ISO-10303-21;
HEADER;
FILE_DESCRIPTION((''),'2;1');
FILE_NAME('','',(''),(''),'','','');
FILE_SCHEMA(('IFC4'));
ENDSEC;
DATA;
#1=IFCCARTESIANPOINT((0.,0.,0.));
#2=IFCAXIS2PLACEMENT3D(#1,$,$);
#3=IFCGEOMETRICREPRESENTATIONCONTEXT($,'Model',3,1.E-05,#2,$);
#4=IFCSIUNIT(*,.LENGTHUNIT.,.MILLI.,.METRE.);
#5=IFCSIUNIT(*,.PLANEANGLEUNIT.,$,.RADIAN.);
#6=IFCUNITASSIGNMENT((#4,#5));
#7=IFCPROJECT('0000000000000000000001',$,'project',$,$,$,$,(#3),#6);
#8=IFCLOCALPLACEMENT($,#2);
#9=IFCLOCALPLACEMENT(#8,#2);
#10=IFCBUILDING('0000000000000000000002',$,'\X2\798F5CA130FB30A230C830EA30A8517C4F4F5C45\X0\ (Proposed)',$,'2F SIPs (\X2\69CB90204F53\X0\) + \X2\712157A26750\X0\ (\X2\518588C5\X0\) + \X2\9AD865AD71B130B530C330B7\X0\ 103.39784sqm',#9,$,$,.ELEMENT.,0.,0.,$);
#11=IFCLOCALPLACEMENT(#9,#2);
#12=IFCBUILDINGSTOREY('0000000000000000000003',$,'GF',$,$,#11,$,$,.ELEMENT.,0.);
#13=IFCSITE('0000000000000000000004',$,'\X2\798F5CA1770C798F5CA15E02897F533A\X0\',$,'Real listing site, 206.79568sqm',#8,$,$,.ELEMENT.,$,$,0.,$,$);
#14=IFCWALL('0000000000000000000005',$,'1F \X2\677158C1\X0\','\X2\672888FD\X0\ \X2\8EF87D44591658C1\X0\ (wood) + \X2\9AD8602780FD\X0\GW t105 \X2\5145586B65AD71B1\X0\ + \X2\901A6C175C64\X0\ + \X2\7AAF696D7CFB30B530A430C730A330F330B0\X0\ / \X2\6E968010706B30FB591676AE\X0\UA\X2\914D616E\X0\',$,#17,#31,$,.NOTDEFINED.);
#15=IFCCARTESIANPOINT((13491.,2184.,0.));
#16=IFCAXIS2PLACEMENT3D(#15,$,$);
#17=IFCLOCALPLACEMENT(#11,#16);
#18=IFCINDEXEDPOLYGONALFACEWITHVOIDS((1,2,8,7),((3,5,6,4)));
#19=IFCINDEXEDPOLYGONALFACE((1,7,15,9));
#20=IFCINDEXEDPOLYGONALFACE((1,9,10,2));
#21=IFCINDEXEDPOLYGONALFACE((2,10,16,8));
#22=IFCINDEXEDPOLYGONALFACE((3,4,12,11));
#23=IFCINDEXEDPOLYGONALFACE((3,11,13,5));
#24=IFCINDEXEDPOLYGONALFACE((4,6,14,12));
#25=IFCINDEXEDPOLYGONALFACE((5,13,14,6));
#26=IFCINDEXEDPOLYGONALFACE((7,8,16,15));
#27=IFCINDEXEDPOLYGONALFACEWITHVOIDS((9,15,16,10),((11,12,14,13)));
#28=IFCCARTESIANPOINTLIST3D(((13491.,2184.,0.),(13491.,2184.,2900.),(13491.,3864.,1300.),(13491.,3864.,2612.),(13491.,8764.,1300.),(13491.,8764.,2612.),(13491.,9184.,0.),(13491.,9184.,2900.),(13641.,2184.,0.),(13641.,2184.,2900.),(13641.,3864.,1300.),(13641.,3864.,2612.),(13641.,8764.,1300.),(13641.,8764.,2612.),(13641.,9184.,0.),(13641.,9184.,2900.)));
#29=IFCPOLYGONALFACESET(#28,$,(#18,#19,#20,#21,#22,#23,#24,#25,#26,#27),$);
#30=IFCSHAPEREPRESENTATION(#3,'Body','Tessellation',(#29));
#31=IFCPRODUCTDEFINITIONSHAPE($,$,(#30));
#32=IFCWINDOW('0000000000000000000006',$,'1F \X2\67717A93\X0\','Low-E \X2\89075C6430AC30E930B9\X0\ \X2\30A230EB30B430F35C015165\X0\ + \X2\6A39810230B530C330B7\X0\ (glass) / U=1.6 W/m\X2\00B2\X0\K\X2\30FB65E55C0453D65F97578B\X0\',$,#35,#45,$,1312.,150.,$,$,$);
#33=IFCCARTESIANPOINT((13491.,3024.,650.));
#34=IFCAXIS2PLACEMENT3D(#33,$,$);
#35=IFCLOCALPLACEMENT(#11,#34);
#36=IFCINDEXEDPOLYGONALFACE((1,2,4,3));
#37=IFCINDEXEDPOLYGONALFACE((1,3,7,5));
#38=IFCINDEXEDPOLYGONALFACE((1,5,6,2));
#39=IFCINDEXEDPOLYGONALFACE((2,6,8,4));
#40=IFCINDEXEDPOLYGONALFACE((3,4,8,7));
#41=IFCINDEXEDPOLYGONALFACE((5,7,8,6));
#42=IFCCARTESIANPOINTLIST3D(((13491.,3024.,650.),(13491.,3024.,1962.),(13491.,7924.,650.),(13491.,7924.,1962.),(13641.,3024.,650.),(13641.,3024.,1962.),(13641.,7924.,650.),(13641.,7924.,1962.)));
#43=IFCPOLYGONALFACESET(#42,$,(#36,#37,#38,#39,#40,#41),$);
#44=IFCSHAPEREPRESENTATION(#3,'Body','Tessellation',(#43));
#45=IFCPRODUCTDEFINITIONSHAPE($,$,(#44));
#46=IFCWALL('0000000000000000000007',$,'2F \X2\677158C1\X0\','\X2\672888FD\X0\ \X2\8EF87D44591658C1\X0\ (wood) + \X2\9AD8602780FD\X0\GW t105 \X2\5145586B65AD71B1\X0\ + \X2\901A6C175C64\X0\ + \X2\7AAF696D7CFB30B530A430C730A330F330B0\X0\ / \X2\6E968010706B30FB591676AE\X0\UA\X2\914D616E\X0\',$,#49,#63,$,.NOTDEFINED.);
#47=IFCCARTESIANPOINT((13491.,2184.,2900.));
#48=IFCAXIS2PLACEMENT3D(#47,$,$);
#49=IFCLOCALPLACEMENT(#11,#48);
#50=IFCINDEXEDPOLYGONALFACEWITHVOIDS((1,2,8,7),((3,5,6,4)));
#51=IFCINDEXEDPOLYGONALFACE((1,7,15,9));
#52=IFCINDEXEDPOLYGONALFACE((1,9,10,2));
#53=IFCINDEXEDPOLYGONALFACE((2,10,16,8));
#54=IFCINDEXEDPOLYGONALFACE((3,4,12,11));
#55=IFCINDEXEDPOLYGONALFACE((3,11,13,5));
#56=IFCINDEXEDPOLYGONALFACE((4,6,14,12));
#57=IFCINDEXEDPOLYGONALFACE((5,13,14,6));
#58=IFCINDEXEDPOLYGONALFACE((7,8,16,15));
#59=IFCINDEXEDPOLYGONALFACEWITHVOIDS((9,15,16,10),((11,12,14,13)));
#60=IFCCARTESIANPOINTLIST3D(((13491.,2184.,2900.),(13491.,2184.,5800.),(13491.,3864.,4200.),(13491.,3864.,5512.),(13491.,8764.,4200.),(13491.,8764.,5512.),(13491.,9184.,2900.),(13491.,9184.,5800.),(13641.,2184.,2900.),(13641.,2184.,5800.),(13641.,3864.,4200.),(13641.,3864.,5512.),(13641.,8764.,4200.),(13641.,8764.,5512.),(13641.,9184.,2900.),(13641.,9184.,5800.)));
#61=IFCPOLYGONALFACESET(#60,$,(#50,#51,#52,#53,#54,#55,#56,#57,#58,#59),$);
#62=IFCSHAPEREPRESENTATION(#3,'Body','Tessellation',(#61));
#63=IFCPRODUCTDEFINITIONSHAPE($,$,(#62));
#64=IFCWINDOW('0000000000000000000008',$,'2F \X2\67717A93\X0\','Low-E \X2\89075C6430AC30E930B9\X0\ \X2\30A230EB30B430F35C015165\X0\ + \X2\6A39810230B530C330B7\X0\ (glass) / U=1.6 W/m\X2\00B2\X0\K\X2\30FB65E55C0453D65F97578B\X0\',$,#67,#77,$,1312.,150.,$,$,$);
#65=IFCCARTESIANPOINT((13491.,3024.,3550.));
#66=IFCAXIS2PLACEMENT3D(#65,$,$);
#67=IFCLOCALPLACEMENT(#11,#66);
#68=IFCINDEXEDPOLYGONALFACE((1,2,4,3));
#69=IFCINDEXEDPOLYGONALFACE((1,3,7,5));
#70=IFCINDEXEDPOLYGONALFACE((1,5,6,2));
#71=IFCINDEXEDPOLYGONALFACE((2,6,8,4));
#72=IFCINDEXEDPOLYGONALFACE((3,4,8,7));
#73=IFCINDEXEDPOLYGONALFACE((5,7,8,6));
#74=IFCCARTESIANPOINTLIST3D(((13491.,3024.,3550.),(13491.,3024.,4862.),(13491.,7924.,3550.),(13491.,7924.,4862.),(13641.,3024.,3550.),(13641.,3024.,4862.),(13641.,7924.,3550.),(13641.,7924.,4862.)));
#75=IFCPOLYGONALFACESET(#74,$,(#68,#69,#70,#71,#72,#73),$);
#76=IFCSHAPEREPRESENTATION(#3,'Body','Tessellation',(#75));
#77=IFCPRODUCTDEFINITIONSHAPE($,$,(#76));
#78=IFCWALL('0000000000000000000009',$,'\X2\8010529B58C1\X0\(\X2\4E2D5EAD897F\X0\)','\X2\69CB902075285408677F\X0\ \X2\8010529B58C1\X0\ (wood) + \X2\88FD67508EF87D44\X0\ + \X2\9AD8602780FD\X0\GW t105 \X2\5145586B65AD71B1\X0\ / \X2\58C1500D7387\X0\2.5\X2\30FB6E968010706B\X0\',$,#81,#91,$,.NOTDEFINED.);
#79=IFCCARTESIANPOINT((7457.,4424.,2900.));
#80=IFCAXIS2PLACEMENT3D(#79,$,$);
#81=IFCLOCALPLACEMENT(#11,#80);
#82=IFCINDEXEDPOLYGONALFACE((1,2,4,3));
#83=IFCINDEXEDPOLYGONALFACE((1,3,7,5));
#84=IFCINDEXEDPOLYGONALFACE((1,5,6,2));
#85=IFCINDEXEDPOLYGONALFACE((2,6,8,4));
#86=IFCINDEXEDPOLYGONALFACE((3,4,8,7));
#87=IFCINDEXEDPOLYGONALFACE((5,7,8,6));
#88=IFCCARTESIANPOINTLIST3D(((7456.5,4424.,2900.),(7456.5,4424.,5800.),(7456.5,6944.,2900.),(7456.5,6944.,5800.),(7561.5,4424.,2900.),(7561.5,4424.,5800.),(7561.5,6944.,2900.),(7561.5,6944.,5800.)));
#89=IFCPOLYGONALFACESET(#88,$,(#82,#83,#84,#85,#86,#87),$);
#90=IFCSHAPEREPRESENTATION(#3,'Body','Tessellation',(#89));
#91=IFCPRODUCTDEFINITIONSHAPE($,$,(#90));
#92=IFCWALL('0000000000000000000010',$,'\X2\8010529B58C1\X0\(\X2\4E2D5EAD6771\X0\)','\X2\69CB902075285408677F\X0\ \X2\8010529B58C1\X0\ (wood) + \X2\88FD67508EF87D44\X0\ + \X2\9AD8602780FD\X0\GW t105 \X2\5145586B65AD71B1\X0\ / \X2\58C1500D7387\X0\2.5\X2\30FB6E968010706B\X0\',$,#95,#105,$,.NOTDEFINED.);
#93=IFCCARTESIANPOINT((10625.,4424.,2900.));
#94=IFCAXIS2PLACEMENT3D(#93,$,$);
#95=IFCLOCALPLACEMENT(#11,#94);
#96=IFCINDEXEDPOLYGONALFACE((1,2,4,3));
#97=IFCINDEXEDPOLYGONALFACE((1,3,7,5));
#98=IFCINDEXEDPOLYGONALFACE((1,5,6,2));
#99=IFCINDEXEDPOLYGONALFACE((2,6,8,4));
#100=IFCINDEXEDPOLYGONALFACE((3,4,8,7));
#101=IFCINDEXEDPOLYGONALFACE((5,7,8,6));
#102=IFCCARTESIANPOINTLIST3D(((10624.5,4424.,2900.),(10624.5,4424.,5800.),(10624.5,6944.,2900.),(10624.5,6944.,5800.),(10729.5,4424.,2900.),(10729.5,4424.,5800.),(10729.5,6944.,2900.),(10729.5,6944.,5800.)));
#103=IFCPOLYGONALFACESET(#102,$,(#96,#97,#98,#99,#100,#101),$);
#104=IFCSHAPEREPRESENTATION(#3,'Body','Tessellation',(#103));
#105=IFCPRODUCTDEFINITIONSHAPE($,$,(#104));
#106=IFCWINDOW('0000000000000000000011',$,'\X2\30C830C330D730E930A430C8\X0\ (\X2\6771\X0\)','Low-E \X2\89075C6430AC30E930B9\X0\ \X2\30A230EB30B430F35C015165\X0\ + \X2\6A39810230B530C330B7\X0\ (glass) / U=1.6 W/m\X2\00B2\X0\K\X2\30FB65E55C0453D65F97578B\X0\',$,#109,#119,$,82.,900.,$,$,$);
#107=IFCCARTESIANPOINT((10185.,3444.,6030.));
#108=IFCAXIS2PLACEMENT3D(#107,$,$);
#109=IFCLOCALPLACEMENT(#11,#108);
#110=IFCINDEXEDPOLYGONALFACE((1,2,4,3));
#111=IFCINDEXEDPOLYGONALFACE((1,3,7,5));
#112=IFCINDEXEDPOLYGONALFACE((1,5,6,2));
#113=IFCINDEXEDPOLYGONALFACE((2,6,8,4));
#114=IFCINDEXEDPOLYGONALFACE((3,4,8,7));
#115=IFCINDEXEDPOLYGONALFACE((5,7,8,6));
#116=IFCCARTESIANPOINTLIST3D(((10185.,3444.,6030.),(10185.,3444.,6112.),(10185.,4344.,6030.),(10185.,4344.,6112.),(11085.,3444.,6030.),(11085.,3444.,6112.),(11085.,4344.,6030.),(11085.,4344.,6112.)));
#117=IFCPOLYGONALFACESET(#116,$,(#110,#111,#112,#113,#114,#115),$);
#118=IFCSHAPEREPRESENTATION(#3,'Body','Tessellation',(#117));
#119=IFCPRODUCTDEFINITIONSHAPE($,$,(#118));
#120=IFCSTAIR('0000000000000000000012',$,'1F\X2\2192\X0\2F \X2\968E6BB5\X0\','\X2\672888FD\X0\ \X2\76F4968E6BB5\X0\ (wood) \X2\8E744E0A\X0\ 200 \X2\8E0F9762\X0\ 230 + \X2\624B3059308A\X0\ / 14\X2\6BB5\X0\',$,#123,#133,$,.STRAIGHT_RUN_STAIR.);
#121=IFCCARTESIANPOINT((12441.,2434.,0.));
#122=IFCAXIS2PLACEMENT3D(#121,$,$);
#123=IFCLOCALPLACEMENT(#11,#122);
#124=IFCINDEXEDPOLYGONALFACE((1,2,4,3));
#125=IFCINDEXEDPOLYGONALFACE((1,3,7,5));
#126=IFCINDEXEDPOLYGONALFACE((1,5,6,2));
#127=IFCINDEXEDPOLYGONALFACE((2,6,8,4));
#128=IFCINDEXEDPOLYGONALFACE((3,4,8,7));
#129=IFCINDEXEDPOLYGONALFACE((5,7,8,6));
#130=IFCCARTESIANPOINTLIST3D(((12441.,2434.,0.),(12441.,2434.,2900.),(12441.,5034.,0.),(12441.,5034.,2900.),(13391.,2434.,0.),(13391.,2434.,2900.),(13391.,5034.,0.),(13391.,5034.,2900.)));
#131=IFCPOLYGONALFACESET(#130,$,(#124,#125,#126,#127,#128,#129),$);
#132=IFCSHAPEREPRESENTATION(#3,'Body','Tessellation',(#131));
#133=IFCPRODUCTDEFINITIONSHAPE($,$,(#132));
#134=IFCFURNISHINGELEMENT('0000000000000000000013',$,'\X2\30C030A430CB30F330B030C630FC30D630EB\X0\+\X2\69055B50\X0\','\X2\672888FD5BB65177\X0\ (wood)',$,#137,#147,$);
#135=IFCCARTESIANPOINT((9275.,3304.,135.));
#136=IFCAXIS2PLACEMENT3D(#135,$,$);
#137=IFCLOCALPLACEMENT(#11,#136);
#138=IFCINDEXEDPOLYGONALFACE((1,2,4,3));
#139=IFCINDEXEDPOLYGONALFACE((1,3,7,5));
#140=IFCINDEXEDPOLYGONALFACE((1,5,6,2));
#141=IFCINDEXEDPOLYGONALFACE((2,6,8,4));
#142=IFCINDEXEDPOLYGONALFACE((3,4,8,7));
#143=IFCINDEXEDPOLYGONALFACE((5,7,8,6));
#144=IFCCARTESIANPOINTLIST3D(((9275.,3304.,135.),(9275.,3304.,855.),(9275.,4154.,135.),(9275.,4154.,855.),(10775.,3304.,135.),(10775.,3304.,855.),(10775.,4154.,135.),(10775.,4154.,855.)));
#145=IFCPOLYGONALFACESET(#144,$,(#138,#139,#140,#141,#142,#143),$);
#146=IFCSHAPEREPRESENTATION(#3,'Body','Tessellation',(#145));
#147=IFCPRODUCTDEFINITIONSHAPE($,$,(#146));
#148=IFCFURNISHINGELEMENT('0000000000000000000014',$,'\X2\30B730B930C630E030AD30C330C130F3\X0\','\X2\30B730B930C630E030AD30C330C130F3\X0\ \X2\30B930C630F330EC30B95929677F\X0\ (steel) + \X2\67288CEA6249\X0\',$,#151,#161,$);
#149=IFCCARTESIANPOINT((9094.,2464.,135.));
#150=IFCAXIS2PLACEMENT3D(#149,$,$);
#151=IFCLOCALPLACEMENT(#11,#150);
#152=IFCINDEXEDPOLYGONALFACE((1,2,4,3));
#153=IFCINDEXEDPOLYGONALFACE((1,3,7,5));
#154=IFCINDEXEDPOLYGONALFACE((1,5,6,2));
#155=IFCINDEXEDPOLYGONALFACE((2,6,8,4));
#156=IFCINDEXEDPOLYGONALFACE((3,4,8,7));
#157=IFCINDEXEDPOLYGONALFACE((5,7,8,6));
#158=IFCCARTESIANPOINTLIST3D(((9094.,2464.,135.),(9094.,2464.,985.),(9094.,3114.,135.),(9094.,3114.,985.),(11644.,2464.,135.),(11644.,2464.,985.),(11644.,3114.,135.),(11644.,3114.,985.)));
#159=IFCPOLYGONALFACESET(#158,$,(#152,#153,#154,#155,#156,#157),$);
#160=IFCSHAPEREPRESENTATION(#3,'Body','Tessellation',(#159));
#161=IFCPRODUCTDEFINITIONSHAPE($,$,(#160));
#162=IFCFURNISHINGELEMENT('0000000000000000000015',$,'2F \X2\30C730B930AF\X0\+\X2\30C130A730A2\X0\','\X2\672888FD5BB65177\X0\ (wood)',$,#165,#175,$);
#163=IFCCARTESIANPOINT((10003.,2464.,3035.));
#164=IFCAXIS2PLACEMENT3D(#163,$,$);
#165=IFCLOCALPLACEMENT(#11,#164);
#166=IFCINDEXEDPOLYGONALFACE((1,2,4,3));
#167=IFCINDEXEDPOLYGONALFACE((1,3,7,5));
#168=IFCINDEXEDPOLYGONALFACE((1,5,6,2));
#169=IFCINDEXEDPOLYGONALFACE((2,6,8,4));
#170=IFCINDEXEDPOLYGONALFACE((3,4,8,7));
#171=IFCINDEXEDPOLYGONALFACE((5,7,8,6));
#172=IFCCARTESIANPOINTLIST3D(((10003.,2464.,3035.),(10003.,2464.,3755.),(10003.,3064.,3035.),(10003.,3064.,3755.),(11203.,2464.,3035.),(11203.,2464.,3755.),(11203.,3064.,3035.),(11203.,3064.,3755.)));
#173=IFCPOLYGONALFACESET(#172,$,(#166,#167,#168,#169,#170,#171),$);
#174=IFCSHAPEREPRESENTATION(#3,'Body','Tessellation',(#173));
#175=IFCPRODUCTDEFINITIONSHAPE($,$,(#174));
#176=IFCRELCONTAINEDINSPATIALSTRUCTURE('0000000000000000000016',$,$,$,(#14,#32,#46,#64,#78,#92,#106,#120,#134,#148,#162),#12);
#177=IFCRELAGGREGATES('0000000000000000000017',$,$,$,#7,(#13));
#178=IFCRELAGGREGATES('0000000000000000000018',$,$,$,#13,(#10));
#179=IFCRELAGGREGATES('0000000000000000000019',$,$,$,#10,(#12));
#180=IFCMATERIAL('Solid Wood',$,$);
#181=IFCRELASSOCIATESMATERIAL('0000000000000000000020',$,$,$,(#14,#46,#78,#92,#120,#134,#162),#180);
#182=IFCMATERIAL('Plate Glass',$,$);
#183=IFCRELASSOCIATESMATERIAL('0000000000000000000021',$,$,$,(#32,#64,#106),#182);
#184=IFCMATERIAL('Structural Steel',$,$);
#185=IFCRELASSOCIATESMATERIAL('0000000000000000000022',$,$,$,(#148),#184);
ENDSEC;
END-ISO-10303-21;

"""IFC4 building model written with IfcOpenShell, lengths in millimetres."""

from ifc_helpers import new_model, si_unit, frame, frame_2d, origin, place, context, project, spatial, rectangle, extrude, material, element, fill, save


model = new_model("IFC4")

# Units and contexts
model_context = context("Model", 3, precision=1e-05, world=origin())
ifc_project = project(units=[si_unit("LENGTHUNIT", "METRE", prefix="MILLI"), si_unit("PLANEANGLEUNIT", "RADIAN")], contexts=[model_context])

# Site, building, storey
site_placement = place(None, origin())
site = spatial("IfcSite", under=ifc_project, at=site_placement, Name="福岡県福岡市西区", ObjectType="Real listing site, 206.79568sqm", CompositionType="ELEMENT", RefElevation=0.0)
building_placement = place(site_placement, origin())
building = spatial("IfcBuilding", under=site, at=building_placement, Name="福岡・アトリエ兼住居 (Proposed)", ObjectType="2F SIPs (構造体) + 無垢材 (内装) + 高断熱サッシ 103.39784sqm", CompositionType="ELEMENT", ElevationOfRefHeight=0.0, ElevationOfTerrain=0.0)
storey_placement = place(building_placement, origin())
storey = spatial("IfcBuildingStorey", under=building, at=storey_placement, Name="GF", CompositionType="ELEMENT", Elevation=0.0)

# Shared definitions
ifc_material_1 = material(Name="Solid Wood")

# Wall, opening, window
wall_1_placement = place(storey_placement, frame((13491.0, 2184.0, 0.0)))
wall_1 = element("IfcWall", 1, at=wall_1_placement, inside=storey, material=ifc_material_1, Name="1F 東壁", Description="木製 軸組外壁 (wood) + 高性能GW t105 充填断熱 + 通気層 + 窯業系サイディング / 準耐火・外皮UA配慮", PredefinedType="NOTDEFINED", context=model_context, shape_type="SweptSolid", body=[
    extrude(rectangle(XDim=150.0, YDim=7000.0, at=frame_2d((75.0, 3500.0))), frame((13491.0, 2184.0, 0.0)), (0.0, 0.0, 1.0), 2900.0),
])
opening_1_placement = place(storey_placement, frame((13491.0, 3024.0, 650.0)))
opening_1 = element("IfcOpeningElement", 2, at=opening_1_placement, cuts=wall_1, PredefinedType="NOTDEFINED", context=model_context, shape_type="SweptSolid", body=[
    extrude(rectangle(XDim=150.0, YDim=4900.0, at=frame_2d((75.0, 2450.0))), frame((13491.0, 3024.0, 650.0)), (0.0, 0.0, 1.0), 1312.0),
])
ifc_material_2 = material(Name="Plate Glass")
window_1_placement = place(storey_placement, frame((13491.0, 3024.0, 650.0)))
window_1 = element("IfcWindow", 3, at=window_1_placement, inside=storey, material=ifc_material_2, Name="1F 東窓", Description="Low-E 複層ガラス アルゴン封入 + 樹脂サッシ (glass) / U=1.6 W/m²K・日射取得型", OverallHeight=1312.0, OverallWidth=150.0, context=model_context, shape_type="SweptSolid", body=[
    extrude(rectangle(XDim=150.0, YDim=4900.0, at=frame_2d((75.0, 2450.0))), frame((13491.0, 3024.0, 650.0)), (0.0, 0.0, 1.0), 1312.0),
])
fill(opening_1, window_1)

# Wall, opening, window
wall_2_placement = place(storey_placement, frame((13491.0, 2184.0, 2900.0)))
wall_2 = element("IfcWall", 4, at=wall_2_placement, inside=storey, material=ifc_material_1, Name="2F 東壁", Description="木製 軸組外壁 (wood) + 高性能GW t105 充填断熱 + 通気層 + 窯業系サイディング / 準耐火・外皮UA配慮", PredefinedType="NOTDEFINED", context=model_context, shape_type="SweptSolid", body=[
    extrude(rectangle(XDim=150.0, YDim=7000.0, at=frame_2d((75.0, 3500.0))), frame((13491.0, 2184.0, 2900.0)), (0.0, 0.0, 1.0), 2900.0),
])
opening_2_placement = place(storey_placement, frame((13491.0, 3024.0, 3550.0)))
opening_2 = element("IfcOpeningElement", 5, at=opening_2_placement, cuts=wall_2, PredefinedType="NOTDEFINED", context=model_context, shape_type="SweptSolid", body=[
    extrude(rectangle(XDim=150.0, YDim=4900.0, at=frame_2d((75.0, 2450.0))), frame((13491.0, 3024.0, 3550.0)), (0.0, 0.0, 1.0), 1312.0),
])
window_2_placement = place(storey_placement, frame((13491.0, 3024.0, 3550.0)))
window_2 = element("IfcWindow", 6, at=window_2_placement, inside=storey, material=ifc_material_2, Name="2F 東窓", Description="Low-E 複層ガラス アルゴン封入 + 樹脂サッシ (glass) / U=1.6 W/m²K・日射取得型", OverallHeight=1312.0, OverallWidth=150.0, context=model_context, shape_type="SweptSolid", body=[
    extrude(rectangle(XDim=150.0, YDim=4900.0, at=frame_2d((75.0, 2450.0))), frame((13491.0, 3024.0, 3550.0)), (0.0, 0.0, 1.0), 1312.0),
])
fill(opening_2, window_2)

# Walls
wall_3_placement = place(storey_placement, frame((7457.0, 4424.0, 2900.0)))
element("IfcWall", 7, at=wall_3_placement, inside=storey, material=ifc_material_1, Name="耐力壁(中庭西)", Description="構造用合板 耐力壁 (wood) + 製材軸組 + 高性能GW t105 充填断熱 / 壁倍率2.5・準耐火", PredefinedType="NOTDEFINED", context=model_context, shape_type="SweptSolid", body=[
    extrude(rectangle(XDim=105.0, YDim=2520.0, at=frame_2d((52.0, 1260.0))), frame((7457.0, 4424.0, 2900.0)), (0.0, 0.0, 1.0), 2900.0),
])
wall_4_placement = place(storey_placement, frame((10625.0, 4424.0, 2900.0)))
element("IfcWall", 8, at=wall_4_placement, inside=storey, material=ifc_material_1, Name="耐力壁(中庭東)", Description="構造用合板 耐力壁 (wood) + 製材軸組 + 高性能GW t105 充填断熱 / 壁倍率2.5・準耐火", PredefinedType="NOTDEFINED", context=model_context, shape_type="SweptSolid", body=[
    extrude(rectangle(XDim=105.0, YDim=2520.0, at=frame_2d((52.0, 1260.0))), frame((10625.0, 4424.0, 2900.0)), (0.0, 0.0, 1.0), 2900.0),
])

# Window
window_3_placement = place(storey_placement, frame((10185.0, 3444.0, 6030.0)))
element("IfcWindow", 9, at=window_3_placement, inside=storey, material=ifc_material_2, Name="トップライト (東)", Description="Low-E 複層ガラス アルゴン封入 + 樹脂サッシ (glass) / U=1.6 W/m²K・日射取得型", OverallHeight=82.0, OverallWidth=900.0, context=model_context, shape_type="SweptSolid", body=[
    extrude(rectangle(XDim=900.0, YDim=900.0, at=frame_2d((450.0, 450.0))), frame((10185.0, 3444.0, 6030.0)), (0.0, 0.0, 1.0), 82.0),
])

# Stair
stair_placement = place(storey_placement, frame((12441.0, 2434.0, 0.0)))
element("IfcStair", 10, at=stair_placement, inside=storey, material=ifc_material_1, Name="1F→2F 階段", Description="木製 直階段 (wood) 蹴上 200 踏面 230 + 手すり / 14段", PredefinedType="STRAIGHT_RUN_STAIR", context=model_context, shape_type="SweptSolid", body=[
    extrude(rectangle(XDim=950.0, YDim=2600.0, at=frame_2d((475.0, 1300.0))), frame((12441.0, 2434.0, 0.0)), (0.0, 0.0, 1.0), 2900.0),
])

# Furnishing elements
furnishing_1_placement = place(storey_placement, frame((9275.0, 3304.0, 135.0)))
element("IfcFurnishingElement", 11, at=furnishing_1_placement, inside=storey, material=ifc_material_1, Name="ダイニングテーブル+椅子", Description="木製家具 (wood)", context=model_context, shape_type="SweptSolid", body=[
    extrude(rectangle(XDim=1500.0, YDim=850.0, at=frame_2d((750.0, 425.0))), frame((9275.0, 3304.0, 135.0)), (0.0, 0.0, 1.0), 720.0),
])
ifc_material_3 = material(Name="Structural Steel")
furnishing_2_placement = place(storey_placement, frame((9094.0, 2464.0, 135.0)))
element("IfcFurnishingElement", 12, at=furnishing_2_placement, inside=storey, material=ifc_material_3, Name="システムキッチン", Description="システムキッチン ステンレス天板 (steel) + 木質扉", context=model_context, shape_type="SweptSolid", body=[
    extrude(rectangle(XDim=2550.0, YDim=650.0, at=frame_2d((1275.0, 325.0))), frame((9094.0, 2464.0, 135.0)), (0.0, 0.0, 1.0), 850.0),
])
furnishing_3_placement = place(storey_placement, frame((10003.0, 2464.0, 3035.0)))
element("IfcFurnishingElement", 13, at=furnishing_3_placement, inside=storey, material=ifc_material_1, Name="2F デスク+チェア", Description="木製家具 (wood)", context=model_context, shape_type="SweptSolid", body=[
    extrude(rectangle(XDim=1200.0, YDim=600.0, at=frame_2d((600.0, 300.0))), frame((10003.0, 2464.0, 3035.0)), (0.0, 0.0, 1.0), 720.0),
])

save(model, "model.ifc")
